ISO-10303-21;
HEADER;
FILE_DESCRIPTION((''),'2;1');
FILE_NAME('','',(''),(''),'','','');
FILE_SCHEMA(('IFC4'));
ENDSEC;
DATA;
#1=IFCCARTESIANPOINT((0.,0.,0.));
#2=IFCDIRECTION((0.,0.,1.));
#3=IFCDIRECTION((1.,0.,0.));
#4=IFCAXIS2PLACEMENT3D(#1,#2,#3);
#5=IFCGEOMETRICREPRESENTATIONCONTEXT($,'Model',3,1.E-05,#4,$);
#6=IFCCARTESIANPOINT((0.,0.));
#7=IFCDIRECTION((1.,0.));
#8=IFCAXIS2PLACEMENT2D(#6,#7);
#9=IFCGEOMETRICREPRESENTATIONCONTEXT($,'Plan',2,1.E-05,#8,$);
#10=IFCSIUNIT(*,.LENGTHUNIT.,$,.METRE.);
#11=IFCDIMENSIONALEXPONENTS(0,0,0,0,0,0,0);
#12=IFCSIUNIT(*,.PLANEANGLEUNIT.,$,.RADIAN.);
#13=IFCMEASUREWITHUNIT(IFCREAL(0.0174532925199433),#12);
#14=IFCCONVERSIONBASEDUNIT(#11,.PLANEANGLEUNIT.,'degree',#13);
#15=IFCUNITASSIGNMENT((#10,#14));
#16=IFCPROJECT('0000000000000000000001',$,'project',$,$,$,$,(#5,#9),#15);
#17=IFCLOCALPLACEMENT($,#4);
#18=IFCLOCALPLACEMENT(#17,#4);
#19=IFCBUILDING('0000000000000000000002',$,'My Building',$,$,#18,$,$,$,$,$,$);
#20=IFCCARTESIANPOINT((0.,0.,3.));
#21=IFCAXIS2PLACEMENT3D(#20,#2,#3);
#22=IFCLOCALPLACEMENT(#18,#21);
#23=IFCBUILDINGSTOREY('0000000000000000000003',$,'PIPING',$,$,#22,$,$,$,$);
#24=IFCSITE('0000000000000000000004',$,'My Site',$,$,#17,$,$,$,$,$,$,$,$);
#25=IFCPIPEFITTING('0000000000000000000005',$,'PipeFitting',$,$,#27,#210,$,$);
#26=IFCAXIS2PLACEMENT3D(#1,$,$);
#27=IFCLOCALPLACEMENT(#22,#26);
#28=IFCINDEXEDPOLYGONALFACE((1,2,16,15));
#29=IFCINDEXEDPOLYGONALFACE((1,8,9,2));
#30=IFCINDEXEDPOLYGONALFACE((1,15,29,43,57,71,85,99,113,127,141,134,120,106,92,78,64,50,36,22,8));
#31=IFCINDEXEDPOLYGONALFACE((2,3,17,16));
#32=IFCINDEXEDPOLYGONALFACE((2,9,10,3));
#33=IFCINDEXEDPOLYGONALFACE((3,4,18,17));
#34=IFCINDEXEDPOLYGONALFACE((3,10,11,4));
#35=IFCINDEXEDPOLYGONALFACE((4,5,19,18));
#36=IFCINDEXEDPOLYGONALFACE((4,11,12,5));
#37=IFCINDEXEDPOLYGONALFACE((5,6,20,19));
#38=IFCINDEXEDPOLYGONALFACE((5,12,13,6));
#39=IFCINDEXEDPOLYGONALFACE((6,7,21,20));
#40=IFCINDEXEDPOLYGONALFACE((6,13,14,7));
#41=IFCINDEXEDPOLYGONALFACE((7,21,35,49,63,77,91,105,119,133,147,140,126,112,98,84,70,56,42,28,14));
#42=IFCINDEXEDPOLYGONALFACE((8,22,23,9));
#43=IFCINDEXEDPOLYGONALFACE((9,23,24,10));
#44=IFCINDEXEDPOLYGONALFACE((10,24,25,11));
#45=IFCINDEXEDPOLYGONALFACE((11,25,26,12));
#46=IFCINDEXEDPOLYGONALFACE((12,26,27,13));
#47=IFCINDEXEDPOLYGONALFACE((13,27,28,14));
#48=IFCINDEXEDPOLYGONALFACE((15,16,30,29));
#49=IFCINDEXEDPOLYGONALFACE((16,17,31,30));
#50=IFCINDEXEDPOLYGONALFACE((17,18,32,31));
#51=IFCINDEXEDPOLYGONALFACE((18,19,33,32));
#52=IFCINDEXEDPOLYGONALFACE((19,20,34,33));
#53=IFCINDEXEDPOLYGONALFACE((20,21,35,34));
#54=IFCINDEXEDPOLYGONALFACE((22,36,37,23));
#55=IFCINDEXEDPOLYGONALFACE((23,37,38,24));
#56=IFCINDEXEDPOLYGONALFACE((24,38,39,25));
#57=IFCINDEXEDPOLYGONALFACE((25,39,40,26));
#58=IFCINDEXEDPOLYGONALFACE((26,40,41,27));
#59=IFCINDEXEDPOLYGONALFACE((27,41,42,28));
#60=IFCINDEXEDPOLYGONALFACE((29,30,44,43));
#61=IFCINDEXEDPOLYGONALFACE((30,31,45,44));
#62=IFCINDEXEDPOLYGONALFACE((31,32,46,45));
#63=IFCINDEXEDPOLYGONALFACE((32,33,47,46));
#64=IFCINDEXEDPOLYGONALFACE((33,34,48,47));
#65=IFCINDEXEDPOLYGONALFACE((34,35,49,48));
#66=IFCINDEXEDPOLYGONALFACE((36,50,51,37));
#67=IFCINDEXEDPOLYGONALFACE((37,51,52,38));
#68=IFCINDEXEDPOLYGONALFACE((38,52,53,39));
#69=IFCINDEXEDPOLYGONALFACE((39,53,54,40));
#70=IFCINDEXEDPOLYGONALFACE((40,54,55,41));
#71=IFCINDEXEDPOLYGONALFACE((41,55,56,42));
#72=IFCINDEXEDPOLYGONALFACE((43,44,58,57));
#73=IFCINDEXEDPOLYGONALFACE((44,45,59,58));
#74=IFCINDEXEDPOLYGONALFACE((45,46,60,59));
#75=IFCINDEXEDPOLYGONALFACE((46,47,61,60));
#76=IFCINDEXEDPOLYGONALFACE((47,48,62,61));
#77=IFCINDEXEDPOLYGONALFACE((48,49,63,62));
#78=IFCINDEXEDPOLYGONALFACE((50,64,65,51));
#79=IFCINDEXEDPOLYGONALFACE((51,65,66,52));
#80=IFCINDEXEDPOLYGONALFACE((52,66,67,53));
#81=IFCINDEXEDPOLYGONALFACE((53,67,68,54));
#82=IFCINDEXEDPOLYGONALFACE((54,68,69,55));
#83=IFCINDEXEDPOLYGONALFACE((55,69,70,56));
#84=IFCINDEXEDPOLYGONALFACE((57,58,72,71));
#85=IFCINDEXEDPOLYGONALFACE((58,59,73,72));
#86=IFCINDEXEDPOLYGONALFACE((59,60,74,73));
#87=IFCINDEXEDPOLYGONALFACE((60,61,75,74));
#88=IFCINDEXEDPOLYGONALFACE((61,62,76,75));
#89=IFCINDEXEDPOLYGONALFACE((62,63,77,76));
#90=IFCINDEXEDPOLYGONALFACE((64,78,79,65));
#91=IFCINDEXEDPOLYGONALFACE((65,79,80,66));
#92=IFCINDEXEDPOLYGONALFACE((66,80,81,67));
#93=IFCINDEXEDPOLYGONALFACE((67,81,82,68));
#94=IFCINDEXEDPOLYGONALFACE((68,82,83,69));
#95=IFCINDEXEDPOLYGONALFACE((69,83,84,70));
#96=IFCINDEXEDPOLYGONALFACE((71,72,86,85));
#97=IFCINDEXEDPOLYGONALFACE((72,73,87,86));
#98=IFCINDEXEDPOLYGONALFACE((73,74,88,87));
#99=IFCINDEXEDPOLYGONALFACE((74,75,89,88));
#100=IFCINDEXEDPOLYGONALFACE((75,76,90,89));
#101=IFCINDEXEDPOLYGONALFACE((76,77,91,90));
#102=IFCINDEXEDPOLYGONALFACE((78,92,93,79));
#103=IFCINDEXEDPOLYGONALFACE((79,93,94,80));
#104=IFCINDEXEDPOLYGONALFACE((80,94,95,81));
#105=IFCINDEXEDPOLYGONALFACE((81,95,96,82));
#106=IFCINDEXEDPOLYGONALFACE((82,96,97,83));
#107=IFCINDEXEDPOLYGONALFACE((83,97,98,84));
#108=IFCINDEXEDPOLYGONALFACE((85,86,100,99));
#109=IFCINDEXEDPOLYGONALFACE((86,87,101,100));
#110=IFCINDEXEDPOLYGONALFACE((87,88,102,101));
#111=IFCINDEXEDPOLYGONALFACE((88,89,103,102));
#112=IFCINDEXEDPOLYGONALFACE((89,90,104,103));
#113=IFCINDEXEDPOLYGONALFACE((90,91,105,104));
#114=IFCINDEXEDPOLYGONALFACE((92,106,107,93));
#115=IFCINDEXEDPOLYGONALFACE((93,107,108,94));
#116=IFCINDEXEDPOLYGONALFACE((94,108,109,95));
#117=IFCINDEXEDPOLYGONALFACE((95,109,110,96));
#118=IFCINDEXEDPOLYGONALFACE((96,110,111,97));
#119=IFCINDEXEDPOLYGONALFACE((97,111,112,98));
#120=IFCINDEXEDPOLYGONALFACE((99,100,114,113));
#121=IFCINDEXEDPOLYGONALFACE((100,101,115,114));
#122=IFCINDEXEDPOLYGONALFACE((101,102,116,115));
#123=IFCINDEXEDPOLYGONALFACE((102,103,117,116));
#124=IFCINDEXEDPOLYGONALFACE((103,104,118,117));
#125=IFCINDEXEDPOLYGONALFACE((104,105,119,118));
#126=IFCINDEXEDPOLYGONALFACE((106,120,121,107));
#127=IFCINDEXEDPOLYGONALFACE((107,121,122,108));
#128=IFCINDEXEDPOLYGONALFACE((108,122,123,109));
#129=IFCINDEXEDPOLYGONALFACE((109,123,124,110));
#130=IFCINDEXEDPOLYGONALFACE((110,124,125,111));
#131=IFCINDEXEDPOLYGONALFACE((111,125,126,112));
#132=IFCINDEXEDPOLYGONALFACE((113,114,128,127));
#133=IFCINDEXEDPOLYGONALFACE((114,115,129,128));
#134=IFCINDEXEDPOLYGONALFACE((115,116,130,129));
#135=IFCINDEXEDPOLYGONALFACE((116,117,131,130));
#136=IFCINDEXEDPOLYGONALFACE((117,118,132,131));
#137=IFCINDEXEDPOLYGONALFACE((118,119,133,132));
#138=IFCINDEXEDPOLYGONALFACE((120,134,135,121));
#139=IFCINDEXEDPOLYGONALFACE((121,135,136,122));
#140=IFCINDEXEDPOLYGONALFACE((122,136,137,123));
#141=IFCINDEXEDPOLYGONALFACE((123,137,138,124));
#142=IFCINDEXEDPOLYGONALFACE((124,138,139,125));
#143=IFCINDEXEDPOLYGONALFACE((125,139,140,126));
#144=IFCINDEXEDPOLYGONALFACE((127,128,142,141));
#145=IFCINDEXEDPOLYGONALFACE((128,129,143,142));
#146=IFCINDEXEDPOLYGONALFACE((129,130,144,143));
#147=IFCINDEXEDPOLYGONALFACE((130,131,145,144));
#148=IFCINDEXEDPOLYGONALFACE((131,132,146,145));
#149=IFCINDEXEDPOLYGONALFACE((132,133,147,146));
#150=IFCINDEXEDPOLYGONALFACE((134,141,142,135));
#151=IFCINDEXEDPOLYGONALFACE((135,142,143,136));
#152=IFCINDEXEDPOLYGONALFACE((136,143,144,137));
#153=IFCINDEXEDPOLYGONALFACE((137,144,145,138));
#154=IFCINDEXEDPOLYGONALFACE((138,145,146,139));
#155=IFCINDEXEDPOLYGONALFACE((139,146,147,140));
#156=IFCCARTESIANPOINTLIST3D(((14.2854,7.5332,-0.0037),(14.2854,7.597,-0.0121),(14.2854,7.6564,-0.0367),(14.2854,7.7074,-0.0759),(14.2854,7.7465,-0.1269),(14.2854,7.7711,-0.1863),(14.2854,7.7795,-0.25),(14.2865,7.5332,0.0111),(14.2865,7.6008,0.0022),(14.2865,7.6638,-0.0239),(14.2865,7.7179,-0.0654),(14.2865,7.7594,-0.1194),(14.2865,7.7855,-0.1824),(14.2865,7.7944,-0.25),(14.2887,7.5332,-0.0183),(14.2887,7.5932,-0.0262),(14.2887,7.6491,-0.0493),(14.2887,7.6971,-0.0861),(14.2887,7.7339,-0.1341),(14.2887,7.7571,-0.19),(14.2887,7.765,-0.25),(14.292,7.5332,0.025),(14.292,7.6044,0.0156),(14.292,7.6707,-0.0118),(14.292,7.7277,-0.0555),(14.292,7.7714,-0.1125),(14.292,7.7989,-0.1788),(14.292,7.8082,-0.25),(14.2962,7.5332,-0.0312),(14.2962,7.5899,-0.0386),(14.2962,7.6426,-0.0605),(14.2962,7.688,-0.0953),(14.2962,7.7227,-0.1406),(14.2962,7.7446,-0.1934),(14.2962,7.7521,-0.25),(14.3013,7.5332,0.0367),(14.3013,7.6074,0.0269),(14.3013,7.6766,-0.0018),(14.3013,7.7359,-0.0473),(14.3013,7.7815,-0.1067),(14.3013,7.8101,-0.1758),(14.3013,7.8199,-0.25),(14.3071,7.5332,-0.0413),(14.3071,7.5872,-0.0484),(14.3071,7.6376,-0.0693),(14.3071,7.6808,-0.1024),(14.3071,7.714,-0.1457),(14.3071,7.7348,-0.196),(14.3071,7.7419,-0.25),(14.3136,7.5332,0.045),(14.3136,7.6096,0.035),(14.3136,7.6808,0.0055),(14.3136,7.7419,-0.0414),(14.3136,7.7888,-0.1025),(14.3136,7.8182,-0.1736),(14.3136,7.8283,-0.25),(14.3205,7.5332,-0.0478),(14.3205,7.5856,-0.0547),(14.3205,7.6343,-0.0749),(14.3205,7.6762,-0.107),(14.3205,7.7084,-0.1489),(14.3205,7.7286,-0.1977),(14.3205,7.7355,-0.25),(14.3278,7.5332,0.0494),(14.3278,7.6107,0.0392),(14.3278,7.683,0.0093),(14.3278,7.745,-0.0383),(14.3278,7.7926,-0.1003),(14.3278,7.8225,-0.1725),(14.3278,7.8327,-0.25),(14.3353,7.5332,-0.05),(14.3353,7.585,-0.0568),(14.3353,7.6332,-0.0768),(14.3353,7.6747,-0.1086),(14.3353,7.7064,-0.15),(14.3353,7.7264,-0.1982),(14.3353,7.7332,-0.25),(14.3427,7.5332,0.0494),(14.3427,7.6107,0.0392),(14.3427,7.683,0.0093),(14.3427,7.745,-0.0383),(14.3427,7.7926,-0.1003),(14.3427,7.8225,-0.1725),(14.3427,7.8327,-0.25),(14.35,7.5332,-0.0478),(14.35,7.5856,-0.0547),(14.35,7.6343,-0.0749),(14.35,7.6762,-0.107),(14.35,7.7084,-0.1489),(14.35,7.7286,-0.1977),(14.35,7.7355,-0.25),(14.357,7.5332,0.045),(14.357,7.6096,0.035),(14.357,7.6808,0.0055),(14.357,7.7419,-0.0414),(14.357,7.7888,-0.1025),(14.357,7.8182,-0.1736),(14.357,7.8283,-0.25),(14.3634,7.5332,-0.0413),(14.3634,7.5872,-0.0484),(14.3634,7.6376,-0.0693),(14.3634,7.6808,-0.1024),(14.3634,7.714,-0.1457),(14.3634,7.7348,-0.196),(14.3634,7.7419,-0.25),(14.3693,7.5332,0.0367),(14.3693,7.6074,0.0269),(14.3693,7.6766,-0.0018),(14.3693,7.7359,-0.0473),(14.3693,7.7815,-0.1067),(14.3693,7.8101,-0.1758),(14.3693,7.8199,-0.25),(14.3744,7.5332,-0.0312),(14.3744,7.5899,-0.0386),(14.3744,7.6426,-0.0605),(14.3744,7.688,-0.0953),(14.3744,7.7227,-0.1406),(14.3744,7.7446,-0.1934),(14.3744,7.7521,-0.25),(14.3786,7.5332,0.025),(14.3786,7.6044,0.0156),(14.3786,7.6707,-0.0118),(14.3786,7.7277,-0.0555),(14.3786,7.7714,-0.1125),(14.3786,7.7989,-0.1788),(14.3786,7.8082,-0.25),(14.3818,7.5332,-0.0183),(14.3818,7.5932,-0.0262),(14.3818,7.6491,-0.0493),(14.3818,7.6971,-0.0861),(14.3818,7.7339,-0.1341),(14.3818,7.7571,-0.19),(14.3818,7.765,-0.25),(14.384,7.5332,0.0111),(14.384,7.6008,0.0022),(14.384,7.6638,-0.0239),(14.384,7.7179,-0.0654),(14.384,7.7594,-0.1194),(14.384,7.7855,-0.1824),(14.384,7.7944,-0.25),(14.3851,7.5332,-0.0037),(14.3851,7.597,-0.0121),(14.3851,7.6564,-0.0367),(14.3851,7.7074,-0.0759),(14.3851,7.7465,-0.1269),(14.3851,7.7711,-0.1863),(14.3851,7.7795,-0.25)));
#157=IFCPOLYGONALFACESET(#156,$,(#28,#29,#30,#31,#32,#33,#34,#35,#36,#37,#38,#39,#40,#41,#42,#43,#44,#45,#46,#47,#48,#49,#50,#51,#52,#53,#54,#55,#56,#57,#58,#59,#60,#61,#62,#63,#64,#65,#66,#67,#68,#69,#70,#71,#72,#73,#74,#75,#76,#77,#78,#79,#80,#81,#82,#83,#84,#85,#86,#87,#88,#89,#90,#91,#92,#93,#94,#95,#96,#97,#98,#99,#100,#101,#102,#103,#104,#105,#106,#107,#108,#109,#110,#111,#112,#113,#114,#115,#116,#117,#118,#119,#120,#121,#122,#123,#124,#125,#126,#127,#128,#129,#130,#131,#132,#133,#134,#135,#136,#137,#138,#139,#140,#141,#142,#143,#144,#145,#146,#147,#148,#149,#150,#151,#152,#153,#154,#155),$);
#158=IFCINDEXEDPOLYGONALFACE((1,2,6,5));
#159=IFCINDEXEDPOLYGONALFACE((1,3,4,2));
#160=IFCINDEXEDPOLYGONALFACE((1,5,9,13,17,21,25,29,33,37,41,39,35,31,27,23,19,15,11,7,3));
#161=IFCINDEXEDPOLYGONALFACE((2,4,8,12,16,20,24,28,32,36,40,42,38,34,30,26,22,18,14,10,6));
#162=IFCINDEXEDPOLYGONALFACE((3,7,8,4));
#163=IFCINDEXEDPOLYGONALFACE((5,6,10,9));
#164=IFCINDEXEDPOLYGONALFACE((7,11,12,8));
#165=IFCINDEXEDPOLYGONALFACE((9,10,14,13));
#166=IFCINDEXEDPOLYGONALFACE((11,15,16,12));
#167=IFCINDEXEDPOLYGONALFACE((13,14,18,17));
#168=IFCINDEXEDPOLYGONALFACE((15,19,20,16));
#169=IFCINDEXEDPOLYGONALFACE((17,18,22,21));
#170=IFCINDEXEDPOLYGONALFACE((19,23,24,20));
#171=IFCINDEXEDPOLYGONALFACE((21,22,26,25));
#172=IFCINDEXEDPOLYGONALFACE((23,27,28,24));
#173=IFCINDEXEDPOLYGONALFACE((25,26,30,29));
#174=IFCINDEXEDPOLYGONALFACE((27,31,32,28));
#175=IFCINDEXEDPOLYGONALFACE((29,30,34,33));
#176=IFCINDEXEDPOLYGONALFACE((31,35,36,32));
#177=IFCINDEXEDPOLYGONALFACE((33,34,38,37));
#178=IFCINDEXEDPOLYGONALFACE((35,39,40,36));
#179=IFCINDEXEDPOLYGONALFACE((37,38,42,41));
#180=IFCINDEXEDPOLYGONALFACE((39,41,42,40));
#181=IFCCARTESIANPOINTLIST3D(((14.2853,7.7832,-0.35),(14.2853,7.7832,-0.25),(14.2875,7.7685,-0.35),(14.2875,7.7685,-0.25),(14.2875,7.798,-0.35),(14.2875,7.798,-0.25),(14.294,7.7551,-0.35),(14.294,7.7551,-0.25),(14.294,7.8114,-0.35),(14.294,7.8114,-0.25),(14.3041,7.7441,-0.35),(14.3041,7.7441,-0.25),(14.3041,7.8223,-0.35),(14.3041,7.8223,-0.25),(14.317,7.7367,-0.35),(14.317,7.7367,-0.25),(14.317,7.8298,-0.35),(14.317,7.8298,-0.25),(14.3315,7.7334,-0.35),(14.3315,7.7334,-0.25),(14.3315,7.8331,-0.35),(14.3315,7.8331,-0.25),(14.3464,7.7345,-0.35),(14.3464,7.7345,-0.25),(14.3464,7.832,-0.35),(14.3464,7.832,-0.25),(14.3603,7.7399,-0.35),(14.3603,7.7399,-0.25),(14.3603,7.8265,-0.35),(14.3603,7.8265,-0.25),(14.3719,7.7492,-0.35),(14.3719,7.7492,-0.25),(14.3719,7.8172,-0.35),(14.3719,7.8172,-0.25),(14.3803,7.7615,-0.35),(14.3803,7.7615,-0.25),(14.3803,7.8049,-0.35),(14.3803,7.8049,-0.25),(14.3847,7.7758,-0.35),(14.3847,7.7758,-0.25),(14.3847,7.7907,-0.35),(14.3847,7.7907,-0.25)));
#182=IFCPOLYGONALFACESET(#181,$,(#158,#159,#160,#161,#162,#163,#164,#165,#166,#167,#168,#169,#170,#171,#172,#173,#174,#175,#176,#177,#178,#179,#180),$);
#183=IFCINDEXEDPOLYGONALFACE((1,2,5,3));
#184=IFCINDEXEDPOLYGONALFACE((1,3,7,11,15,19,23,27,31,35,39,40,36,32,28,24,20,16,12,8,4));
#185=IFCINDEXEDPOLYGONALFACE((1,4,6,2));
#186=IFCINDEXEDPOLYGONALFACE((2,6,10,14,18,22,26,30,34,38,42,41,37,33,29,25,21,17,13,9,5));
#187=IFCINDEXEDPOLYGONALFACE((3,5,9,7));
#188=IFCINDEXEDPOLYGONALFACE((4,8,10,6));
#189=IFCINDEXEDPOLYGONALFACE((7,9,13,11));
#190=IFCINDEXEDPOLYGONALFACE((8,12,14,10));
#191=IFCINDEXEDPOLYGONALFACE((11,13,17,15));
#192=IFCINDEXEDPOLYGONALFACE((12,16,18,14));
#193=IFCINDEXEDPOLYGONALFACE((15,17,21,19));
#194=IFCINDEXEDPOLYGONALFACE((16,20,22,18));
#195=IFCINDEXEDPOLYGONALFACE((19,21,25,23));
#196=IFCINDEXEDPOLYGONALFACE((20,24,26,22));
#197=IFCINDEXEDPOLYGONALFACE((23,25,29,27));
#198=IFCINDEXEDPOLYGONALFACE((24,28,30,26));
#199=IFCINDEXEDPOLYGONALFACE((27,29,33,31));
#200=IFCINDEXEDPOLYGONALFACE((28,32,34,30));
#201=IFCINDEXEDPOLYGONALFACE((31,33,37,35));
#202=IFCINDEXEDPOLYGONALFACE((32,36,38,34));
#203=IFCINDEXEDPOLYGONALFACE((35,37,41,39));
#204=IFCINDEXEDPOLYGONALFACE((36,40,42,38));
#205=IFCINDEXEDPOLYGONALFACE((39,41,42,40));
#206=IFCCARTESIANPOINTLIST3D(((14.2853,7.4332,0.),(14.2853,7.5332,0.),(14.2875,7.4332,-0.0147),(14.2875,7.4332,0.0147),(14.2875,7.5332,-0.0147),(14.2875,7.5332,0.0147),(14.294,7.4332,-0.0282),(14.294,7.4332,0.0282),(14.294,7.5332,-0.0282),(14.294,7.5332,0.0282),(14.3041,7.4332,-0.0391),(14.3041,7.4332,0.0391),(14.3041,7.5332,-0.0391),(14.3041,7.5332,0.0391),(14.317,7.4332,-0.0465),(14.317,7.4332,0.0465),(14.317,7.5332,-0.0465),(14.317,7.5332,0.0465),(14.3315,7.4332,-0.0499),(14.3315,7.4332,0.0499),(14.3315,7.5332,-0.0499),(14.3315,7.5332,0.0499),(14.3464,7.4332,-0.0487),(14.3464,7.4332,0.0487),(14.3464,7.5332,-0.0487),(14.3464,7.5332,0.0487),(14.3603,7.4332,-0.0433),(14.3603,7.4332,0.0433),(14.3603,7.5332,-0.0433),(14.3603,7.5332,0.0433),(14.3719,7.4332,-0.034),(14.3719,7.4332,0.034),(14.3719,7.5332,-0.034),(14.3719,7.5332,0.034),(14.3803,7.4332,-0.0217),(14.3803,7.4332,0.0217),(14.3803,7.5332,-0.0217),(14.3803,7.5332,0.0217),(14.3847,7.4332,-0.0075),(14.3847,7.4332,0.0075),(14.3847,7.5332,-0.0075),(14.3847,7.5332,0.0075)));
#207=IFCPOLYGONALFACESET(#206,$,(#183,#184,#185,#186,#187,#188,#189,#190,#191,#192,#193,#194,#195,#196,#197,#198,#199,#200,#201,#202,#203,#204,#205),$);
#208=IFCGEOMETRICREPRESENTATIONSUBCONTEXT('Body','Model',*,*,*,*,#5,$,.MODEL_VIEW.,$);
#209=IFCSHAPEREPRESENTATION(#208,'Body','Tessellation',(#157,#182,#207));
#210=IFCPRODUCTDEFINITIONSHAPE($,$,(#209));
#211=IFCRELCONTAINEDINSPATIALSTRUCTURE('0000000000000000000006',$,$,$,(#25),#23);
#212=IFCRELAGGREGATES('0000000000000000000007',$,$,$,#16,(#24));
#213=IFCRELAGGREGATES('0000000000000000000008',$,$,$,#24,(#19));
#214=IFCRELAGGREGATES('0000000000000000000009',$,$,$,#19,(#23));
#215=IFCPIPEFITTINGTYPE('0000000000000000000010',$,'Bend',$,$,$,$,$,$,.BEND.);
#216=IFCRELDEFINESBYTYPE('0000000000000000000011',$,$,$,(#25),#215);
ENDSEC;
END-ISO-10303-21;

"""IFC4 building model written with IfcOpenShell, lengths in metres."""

from ifc_helpers import new_model, entity, si_unit, converted_unit, frame, origin_with_axes, origin_2d_with_axis, place, context, subcontext, project, spatial, circle, extrude, source, transform, mapped, type_object, type_shapes, element, save


model = new_model("IFC4")

# Units and contexts
model_context = context("Model", 3, precision=1e-05, world=origin_with_axes())
plan_context = context("Plan", 2, precision=1e-05, world=origin_2d_with_axis())
body_context = subcontext(model_context, "Body", "Model", "MODEL_VIEW")
ifc_project = project(units=[si_unit("LENGTHUNIT", "METRE"), converted_unit("PLANEANGLEUNIT", "degree", entity("IfcReal", 0.0174532925199433), si_unit("PLANEANGLEUNIT", "RADIAN"), dimensions=[0, 0, 0, 0, 0, 0, 0])], contexts=[model_context, plan_context])

# Site, building, storey
site_placement = place(None, origin_with_axes())
site = spatial("IfcSite", under=ifc_project, at=site_placement, Name="My Site")
building_placement = place(site_placement, origin_with_axes())
building = spatial("IfcBuilding", under=site, at=building_placement, Name="My Building")
storey_placement = place(building_placement, frame((0.0, 0.0, 3.0), z_axis=(0.0, 0.0, 1.0), x_axis=(1.0, 0.0, 0.0)))
storey = spatial("IfcBuildingStorey", under=building, at=storey_placement, Name="PIPING")

# Pipe fitting
pipe_fitting_type_1 = type_object("IfcPipeFittingType", Name="Bend", PredefinedType="BEND")
shared_shape = source(origin_with_axes(), body_context, "Body", "SolidModel", [
    entity("IfcSweptDiskSolid", entity("IfcIndexedPolyCurve", entity("IfcCartesianPointList3D", [[0.0, 0.0, -0.1], [0.0, -0.0732, -0.2768], [0.0, -0.25, -0.35]]), [entity("IfcArcIndex", [1, 2, 3])]), 0.05),
    extrude(circle(Radius=0.05), origin_with_axes(), (0.0, 0.0, -1.0), 0.1),
    extrude(circle(Radius=0.05), frame((0.0, -0.25, -0.35), z_axis=(0.0, -1.0, 0.0), x_axis=(1.0, 0.0, 0.0)), (0.0, 0.0, 1.0), 0.1),
])
type_shapes(pipe_fitting_type_1, [shared_shape])
for number, where, z_axis, x_axis, name in (
    (1, (14.3353, 7.7832, -0.35), (0.0, 0.0, -1.0), (-1.0, 0.0, 0.0), "PipeFitting"),
):
    element("IfcPipeFitting", number, at=place(storey_placement, frame(where, z_axis=z_axis, x_axis=x_axis)), inside=storey, type_object=pipe_fitting_type_1, Name=name, context=body_context, shape_type="MappedRepresentation", body=[
        mapped(shared_shape, transform((0.0, 0.0, 0.0), x_axis=(1.0, 0.0, 0.0), y_axis=(0.0, 1.0, 0.0), z_axis=(0.0, 0.0, 1.0), scale=1.0)),
    ])

save(model, "model.ifc")
